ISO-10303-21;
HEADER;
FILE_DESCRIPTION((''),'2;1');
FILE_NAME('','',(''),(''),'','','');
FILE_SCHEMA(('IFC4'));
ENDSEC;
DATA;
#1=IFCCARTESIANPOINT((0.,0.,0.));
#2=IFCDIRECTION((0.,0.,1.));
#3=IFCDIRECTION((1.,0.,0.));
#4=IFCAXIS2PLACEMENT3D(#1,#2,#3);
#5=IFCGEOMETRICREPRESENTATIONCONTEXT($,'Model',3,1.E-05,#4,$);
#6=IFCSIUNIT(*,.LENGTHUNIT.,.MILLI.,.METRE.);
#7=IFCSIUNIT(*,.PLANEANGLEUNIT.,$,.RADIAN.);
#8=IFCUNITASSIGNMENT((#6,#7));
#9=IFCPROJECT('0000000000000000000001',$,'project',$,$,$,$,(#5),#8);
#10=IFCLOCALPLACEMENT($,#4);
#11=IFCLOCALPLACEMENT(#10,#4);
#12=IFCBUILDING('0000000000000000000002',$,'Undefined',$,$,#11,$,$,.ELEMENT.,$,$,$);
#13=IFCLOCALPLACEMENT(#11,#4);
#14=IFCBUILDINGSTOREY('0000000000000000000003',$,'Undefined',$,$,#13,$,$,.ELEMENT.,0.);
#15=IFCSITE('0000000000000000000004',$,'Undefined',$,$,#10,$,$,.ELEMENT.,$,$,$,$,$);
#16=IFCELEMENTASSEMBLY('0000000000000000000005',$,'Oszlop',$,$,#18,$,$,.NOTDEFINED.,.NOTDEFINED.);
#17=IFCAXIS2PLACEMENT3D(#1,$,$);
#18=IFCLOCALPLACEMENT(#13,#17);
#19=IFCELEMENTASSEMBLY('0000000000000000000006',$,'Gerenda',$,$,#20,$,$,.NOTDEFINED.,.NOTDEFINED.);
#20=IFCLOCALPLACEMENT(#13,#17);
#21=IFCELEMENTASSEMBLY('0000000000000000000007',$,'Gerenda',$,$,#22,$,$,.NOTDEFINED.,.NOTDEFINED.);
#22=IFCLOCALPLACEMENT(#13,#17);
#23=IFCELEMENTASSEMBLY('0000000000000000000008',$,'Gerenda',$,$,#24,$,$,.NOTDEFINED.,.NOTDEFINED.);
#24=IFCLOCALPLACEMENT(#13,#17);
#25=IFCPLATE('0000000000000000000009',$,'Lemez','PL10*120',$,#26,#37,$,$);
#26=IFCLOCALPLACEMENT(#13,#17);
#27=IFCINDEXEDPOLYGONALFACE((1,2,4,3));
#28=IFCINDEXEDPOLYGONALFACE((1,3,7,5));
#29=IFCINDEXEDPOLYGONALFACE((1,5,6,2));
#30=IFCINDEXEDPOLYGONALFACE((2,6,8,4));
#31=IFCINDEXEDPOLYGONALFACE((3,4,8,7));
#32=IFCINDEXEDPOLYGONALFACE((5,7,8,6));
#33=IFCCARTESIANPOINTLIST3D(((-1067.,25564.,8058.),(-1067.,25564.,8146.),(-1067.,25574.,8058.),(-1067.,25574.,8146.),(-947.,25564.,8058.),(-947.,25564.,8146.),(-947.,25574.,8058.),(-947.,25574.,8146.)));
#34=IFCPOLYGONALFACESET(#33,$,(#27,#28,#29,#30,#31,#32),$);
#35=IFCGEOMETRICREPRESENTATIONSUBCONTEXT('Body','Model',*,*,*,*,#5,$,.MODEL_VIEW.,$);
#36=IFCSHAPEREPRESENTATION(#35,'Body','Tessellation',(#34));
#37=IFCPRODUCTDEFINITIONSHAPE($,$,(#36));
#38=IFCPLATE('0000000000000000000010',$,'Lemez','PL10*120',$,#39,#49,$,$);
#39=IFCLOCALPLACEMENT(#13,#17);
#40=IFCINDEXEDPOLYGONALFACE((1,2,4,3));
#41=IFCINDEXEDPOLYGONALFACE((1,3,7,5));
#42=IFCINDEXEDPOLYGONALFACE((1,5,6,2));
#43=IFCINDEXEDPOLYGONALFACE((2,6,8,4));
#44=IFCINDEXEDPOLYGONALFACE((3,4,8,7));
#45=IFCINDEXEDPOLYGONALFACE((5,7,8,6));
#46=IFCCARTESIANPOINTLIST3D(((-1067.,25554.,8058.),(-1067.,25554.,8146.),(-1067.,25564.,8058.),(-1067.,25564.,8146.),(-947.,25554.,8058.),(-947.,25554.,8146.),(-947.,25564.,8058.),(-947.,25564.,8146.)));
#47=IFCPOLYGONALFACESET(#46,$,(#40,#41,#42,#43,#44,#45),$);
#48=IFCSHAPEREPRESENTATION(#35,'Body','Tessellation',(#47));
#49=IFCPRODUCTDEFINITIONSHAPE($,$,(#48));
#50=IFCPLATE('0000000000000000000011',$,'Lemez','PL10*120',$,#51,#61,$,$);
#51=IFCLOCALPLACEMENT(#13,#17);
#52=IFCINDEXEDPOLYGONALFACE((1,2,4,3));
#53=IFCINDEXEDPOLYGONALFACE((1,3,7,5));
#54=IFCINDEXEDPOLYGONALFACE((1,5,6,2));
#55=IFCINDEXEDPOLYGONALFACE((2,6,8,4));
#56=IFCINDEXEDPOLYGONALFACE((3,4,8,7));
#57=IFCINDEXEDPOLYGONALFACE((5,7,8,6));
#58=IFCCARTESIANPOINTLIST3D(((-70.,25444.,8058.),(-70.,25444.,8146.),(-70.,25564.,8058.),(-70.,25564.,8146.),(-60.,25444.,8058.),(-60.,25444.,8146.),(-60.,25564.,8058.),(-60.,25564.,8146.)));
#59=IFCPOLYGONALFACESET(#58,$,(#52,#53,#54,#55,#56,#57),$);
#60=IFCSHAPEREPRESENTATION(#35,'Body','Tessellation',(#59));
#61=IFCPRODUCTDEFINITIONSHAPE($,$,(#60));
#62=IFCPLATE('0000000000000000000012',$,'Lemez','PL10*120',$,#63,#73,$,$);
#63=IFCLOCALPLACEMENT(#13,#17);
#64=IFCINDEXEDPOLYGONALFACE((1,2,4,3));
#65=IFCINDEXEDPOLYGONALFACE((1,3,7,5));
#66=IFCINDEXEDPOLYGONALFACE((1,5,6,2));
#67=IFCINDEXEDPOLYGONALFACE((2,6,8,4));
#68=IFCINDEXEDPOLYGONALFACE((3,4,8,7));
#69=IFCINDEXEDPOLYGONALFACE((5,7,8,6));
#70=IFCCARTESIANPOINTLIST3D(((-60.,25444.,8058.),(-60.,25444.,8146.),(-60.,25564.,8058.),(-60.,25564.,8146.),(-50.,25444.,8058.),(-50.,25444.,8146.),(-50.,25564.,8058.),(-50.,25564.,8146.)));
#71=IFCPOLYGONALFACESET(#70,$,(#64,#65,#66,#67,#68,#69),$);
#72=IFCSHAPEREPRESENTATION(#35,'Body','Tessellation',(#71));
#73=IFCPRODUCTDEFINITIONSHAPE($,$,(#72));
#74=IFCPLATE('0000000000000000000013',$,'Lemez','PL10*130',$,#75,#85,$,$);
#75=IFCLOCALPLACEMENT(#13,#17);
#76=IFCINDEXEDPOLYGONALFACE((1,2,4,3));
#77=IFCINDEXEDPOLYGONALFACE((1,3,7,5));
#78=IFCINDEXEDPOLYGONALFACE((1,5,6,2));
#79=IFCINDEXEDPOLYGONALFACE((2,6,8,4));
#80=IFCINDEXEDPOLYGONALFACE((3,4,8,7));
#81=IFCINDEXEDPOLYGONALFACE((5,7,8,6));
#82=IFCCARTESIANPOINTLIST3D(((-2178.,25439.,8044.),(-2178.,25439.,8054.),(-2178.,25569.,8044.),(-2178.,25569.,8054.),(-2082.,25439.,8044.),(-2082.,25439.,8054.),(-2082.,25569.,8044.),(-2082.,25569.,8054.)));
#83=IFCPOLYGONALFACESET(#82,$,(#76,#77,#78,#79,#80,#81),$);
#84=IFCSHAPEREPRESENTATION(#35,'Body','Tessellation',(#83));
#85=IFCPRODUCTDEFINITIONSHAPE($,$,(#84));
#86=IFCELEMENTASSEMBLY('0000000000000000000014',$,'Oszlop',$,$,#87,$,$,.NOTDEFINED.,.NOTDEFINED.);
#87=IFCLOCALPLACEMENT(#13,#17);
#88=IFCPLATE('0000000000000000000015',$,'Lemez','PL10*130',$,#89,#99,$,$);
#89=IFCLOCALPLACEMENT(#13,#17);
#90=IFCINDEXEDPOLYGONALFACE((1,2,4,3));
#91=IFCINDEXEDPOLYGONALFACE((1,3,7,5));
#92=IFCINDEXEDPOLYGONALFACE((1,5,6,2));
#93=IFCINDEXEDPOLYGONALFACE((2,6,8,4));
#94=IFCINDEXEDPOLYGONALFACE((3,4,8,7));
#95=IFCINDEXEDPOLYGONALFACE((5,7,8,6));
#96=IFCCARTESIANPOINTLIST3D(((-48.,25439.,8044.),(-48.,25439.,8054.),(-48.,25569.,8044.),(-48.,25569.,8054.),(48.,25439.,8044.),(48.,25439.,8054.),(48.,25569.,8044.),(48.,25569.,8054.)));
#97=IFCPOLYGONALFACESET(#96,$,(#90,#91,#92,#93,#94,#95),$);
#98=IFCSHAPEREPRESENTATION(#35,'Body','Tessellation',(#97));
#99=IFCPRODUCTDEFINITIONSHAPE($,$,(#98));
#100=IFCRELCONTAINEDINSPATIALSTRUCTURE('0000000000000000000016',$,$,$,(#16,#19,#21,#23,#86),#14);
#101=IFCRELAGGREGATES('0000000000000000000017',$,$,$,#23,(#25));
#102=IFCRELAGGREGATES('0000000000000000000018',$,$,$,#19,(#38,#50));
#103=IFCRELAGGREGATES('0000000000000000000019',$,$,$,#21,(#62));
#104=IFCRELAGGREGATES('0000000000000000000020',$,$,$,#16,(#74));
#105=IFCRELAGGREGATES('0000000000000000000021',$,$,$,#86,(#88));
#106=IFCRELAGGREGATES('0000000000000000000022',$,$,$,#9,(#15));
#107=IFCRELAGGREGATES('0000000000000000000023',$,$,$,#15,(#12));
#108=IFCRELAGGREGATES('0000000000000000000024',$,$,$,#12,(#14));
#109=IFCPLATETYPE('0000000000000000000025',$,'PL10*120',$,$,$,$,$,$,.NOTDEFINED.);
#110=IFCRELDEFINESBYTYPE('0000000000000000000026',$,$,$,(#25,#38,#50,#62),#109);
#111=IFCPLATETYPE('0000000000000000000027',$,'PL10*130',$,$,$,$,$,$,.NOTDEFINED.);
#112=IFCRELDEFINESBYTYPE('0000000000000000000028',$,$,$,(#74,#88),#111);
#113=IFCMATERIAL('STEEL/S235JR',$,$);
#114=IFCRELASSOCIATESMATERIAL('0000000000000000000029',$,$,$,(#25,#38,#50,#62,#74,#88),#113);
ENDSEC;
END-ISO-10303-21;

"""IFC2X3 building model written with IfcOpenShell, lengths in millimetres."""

from ifc_helpers import new_model, si_unit, frame, origin_with_axes, place, context, subcontext, project, spatial, polyline, outline, extrude, material, type_object, element, aggregate, save


model = new_model("IFC2X3")

# Units and contexts
model_context = context("Model", 3, precision=1e-05, world=origin_with_axes())
body_context = subcontext(model_context, "Body", "Model", "MODEL_VIEW")
ifc_project = project(units=[si_unit("LENGTHUNIT", "METRE", prefix="MILLI"), si_unit("PLANEANGLEUNIT", "RADIAN")], contexts=[model_context])

# Site, building, storey
site_placement = place(None, origin_with_axes())
site = spatial("IfcSite", under=ifc_project, at=site_placement, Name="Undefined", CompositionType="ELEMENT")
building_placement = place(site_placement, origin_with_axes())
building = spatial("IfcBuilding", under=site, at=building_placement, Name="Undefined", CompositionType="ELEMENT")
storey_placement = place(building_placement, origin_with_axes())
storey = spatial("IfcBuildingStorey", under=building, at=storey_placement, Name="Undefined", CompositionType="ELEMENT", Elevation=0.0)

# Shared definitions
ifc_material_1 = material(Name="STEEL/S235JR")

# Element assemblies
assembly_1_placement = place(storey_placement, origin_with_axes())
assembly_1 = element("IfcElementAssembly", 1, at=assembly_1_placement, inside=storey, Name="Oszlop", AssemblyPlace="NOTDEFINED", PredefinedType="NOTDEFINED")
assembly_2_placement = place(storey_placement, origin_with_axes())
assembly_2 = element("IfcElementAssembly", 2, at=assembly_2_placement, inside=storey, Name="Gerenda", AssemblyPlace="NOTDEFINED", PredefinedType="NOTDEFINED")
assembly_3_placement = place(storey_placement, origin_with_axes())
assembly_3 = element("IfcElementAssembly", 3, at=assembly_3_placement, inside=storey, Name="Gerenda", AssemblyPlace="NOTDEFINED", PredefinedType="NOTDEFINED")
plate_type_1 = type_object("IfcPlateType", Name="PL10*120", PredefinedType="NOTDEFINED")
assembly_4_placement = place(storey_placement, origin_with_axes())
assembly_4 = element("IfcElementAssembly", 4, at=assembly_4_placement, inside=storey, Name="Gerenda", AssemblyPlace="NOTDEFINED", PredefinedType="NOTDEFINED")

# Plates
plate_1_placement = place(assembly_4_placement, frame((-1007.0, 25569.0, 8058.0), z_axis=(0.000003, 1.0, 0.0), x_axis=(0.0, 0.0, 1.0)))
plate_1 = element("IfcPlate", 5, at=plate_1_placement, type_object=plate_type_1, material=ifc_material_1, Name="Lemez", Description="PL10*120", context=body_context, shape_type="SweptSolid", body=[
    extrude(outline(polyline([(0.0, -60.0), (0.0, 60.0), (88.0, 60.0), (88.0, -60.0), (0.0, -60.0)])), frame((0.0, 0.0, -5.0), z_axis=(0.0, 0.0, 1.0), x_axis=(1.0, 0.0, 0.0)), (0.0, 0.0, 1.0), 10.0),
])
aggregate(assembly_4, [plate_1])
plate_2_placement = place(assembly_2_placement, frame((-1007.0, 25559.0, 8058.0), z_axis=(0.000003, 1.0, 0.0), x_axis=(0.0, 0.0, 1.0)))
plate_2 = element("IfcPlate", 6, at=plate_2_placement, type_object=plate_type_1, material=ifc_material_1, Name="Lemez", Description="PL10*120", context=body_context, shape_type="SweptSolid", body=[
    extrude(outline(polyline([(0.0, -60.0), (0.0, 60.0), (88.0, 60.0), (88.0, -60.0), (0.0, -60.0)])), frame((0.0, 0.0, -5.0), z_axis=(0.0, 0.0, 1.0), x_axis=(1.0, 0.0, 0.0)), (0.0, 0.0, 1.0), 10.0),
])
plate_3_placement = place(assembly_2_placement, frame((-65.0, 25504.0, 8058.0), z_axis=(-1.0, 0.000003, 0.0), x_axis=(0.0, 0.0, 1.0)))
plate_3 = element("IfcPlate", 7, at=plate_3_placement, type_object=plate_type_1, material=ifc_material_1, Name="Lemez", Description="PL10*120", context=body_context, shape_type="SweptSolid", body=[
    extrude(outline(polyline([(0.0, -60.0), (0.0, 60.0), (88.0, 60.0), (88.0, -60.0), (0.0, -60.0)])), frame((0.0, 0.0, -5.0), z_axis=(0.0, 0.0, 1.0), x_axis=(1.0, 0.0, 0.0)), (0.0, 0.0, 1.0), 10.0),
])
aggregate(assembly_2, [plate_2, plate_3])
plate_4_placement = place(assembly_3_placement, frame((-55.0, 25504.0, 8058.0), z_axis=(-1.0, 0.000003, 0.0), x_axis=(0.0, 0.0, 1.0)))
plate_4 = element("IfcPlate", 8, at=plate_4_placement, type_object=plate_type_1, material=ifc_material_1, Name="Lemez", Description="PL10*120", context=body_context, shape_type="SweptSolid", body=[
    extrude(outline(polyline([(0.0, -60.0), (0.0, 60.0), (88.0, 60.0), (88.0, -60.0), (0.0, -60.0)])), frame((0.0, 0.0, -5.0), z_axis=(0.0, 0.0, 1.0), x_axis=(1.0, 0.0, 0.0)), (0.0, 0.0, 1.0), 10.0),
])
aggregate(assembly_3, [plate_4])
plate_type_2 = type_object("IfcPlateType", Name="PL10*130", PredefinedType="NOTDEFINED")
plate_5_placement = place(assembly_1_placement, frame((-2082.0, 25504.0, 8049.0), z_axis=(0.0, 0.0, -1.0), x_axis=(-1.0, 0.0, 0.0)))
plate_5 = element("IfcPlate", 9, at=plate_5_placement, type_object=plate_type_2, material=ifc_material_1, Name="Lemez", Description="PL10*130", context=body_context, shape_type="SweptSolid", body=[
    extrude(outline(polyline([(0.0, -65.0), (0.0, 65.0), (96.0, 65.0), (96.0, -65.0), (0.0, -65.0)])), frame((0.0, 0.0, -5.0), z_axis=(0.0, 0.0, 1.0), x_axis=(1.0, 0.0, 0.0)), (0.0, 0.0, 1.0), 10.0),
])

# Element assembly, plate
assembly_5_placement = place(storey_placement, origin_with_axes())
assembly_5 = element("IfcElementAssembly", 10, at=assembly_5_placement, inside=storey, Name="Oszlop", AssemblyPlace="NOTDEFINED", PredefinedType="NOTDEFINED")
plate_6_placement = place(assembly_5_placement, frame((48.0, 25504.0, 8049.0), z_axis=(0.0, 0.0, -1.0), x_axis=(-1.0, 0.0, 0.0)))
plate_6 = element("IfcPlate", 11, at=plate_6_placement, type_object=plate_type_2, material=ifc_material_1, Name="Lemez", Description="PL10*130", context=body_context, shape_type="SweptSolid", body=[
    extrude(outline(polyline([(0.0, -65.0), (0.0, 65.0), (96.0, 65.0), (96.0, -65.0), (0.0, -65.0)])), frame((0.0, 0.0, -5.0), z_axis=(0.0, 0.0, 1.0), x_axis=(1.0, 0.0, 0.0)), (0.0, 0.0, 1.0), 10.0),
])

aggregate(assembly_1, [plate_5])
aggregate(assembly_5, [plate_6])

save(model, "model.ifc")
